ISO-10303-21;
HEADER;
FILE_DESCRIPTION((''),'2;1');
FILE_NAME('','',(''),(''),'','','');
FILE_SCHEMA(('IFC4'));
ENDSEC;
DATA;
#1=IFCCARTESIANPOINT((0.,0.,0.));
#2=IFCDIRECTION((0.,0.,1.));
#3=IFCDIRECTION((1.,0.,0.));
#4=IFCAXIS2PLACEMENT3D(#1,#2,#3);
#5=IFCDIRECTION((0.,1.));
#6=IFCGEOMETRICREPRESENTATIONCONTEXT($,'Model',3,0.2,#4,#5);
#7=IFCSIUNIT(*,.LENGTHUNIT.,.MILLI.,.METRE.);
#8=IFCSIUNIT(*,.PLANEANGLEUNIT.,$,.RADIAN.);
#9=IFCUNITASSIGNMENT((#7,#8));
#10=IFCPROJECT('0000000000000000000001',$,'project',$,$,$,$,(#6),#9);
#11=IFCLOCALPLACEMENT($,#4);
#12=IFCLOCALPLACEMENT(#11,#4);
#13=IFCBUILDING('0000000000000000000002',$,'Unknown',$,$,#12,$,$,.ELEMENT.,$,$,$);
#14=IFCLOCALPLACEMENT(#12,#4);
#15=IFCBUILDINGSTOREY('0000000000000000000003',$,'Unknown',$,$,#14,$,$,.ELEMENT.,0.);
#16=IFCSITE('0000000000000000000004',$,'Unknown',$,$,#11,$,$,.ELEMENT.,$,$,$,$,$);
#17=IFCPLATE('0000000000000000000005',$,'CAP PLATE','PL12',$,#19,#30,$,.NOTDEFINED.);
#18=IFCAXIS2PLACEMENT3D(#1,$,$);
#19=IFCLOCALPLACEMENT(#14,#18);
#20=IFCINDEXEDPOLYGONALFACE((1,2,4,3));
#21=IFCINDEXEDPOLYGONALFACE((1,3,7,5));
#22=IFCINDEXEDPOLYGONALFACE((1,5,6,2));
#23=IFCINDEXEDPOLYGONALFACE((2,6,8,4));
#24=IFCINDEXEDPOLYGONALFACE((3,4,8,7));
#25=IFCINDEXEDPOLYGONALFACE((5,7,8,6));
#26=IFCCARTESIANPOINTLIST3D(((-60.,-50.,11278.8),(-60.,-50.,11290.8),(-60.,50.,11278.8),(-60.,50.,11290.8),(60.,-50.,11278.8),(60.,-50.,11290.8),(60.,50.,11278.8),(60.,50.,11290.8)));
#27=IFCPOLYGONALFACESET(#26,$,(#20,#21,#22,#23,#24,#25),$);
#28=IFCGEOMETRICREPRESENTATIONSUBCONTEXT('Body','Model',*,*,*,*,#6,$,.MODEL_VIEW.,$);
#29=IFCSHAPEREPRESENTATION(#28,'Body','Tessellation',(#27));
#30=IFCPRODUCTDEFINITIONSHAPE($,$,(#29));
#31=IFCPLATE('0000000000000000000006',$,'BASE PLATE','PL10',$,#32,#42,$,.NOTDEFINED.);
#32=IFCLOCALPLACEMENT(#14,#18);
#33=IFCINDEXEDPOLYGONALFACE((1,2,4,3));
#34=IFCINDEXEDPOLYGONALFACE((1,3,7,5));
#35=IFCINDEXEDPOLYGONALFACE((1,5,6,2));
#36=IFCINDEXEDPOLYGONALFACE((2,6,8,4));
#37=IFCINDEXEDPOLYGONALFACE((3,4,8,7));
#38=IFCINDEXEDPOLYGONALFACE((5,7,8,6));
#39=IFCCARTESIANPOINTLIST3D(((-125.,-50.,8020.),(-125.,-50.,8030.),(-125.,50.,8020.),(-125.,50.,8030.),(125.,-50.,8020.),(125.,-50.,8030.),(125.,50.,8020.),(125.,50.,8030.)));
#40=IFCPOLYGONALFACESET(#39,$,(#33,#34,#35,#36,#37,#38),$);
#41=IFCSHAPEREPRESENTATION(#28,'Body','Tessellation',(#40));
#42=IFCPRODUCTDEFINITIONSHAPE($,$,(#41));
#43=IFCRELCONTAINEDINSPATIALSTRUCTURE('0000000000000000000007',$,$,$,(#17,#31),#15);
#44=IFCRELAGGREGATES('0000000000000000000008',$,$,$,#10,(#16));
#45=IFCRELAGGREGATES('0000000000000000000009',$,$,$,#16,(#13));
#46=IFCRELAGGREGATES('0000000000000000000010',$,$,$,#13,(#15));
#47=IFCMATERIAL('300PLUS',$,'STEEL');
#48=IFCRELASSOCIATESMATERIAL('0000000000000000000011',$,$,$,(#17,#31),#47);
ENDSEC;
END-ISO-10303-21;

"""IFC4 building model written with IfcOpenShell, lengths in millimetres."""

from ifc_helpers import new_model, si_unit, direction, frame, origin_with_axes, place, context, subcontext, project, spatial, line, indexed_curve, outline, extrude, material, element, save


model = new_model("IFC4")

# Units and contexts
model_context = context("Model", 3, precision=0.2, world=origin_with_axes(), true_north=direction((0.0, 1.0)))
body_context = subcontext(model_context, "Body", "Model", "MODEL_VIEW")
ifc_project = project(units=[si_unit("LENGTHUNIT", "METRE", prefix="MILLI"), si_unit("PLANEANGLEUNIT", "RADIAN")], contexts=[model_context])

# Site, building, storey
site_placement = place(None, origin_with_axes())
site = spatial("IfcSite", under=ifc_project, at=site_placement, Name="Unknown", CompositionType="ELEMENT")
building_placement = place(site_placement, origin_with_axes())
building = spatial("IfcBuilding", under=site, at=building_placement, Name="Unknown", CompositionType="ELEMENT")
storey_placement = place(building_placement, origin_with_axes())
storey = spatial("IfcBuildingStorey", under=building, at=storey_placement, Name="Unknown", CompositionType="ELEMENT", Elevation=0.0)

# Plates
ifc_material_1 = material(Name="300PLUS", Category="STEEL")
plate_1_placement = place(storey_placement, frame((-60.0, -50.0, 11284.8), z_axis=(0.0, 0.0, 1.0), x_axis=(1.0, 0.0, 0.0)))
element("IfcPlate", 1, at=plate_1_placement, inside=storey, material=ifc_material_1, Name="CAP PLATE", Description="PL12", PredefinedType="NOTDEFINED", context=body_context, shape_type="SolidModel", body=[
    extrude(outline(indexed_curve([(0.0, 0.0), (120.0, 0.0), (120.0, 100.0), (0.0, 100.0)], segments=[line(1, 2, 3, 4, 1)])), frame((0.0, 0.0, 6.0), z_axis=(0.0, 0.0, 1.0), x_axis=(1.0, 0.0, 0.0)), (0.0, 0.0, -1.0), 12.0),
])
plate_2_placement = place(storey_placement, frame((-125.0, -50.0, 8025.0), z_axis=(0.0, 0.0, 1.0), x_axis=(1.0, 0.0, 0.0)))
element("IfcPlate", 2, at=plate_2_placement, inside=storey, material=ifc_material_1, Name="BASE PLATE", Description="PL10", PredefinedType="NOTDEFINED", context=body_context, shape_type="SolidModel", body=[
    extrude(outline(indexed_curve([(0.0, 0.0), (250.0, 0.0), (250.0, 100.0), (0.0, 100.0)], segments=[line(1, 2, 3, 4, 1)])), frame((0.0, 0.0, 5.0), z_axis=(0.0, 0.0, 1.0), x_axis=(1.0, 0.0, 0.0)), (0.0, 0.0, -1.0), 10.0),
])

save(model, "model.ifc")
